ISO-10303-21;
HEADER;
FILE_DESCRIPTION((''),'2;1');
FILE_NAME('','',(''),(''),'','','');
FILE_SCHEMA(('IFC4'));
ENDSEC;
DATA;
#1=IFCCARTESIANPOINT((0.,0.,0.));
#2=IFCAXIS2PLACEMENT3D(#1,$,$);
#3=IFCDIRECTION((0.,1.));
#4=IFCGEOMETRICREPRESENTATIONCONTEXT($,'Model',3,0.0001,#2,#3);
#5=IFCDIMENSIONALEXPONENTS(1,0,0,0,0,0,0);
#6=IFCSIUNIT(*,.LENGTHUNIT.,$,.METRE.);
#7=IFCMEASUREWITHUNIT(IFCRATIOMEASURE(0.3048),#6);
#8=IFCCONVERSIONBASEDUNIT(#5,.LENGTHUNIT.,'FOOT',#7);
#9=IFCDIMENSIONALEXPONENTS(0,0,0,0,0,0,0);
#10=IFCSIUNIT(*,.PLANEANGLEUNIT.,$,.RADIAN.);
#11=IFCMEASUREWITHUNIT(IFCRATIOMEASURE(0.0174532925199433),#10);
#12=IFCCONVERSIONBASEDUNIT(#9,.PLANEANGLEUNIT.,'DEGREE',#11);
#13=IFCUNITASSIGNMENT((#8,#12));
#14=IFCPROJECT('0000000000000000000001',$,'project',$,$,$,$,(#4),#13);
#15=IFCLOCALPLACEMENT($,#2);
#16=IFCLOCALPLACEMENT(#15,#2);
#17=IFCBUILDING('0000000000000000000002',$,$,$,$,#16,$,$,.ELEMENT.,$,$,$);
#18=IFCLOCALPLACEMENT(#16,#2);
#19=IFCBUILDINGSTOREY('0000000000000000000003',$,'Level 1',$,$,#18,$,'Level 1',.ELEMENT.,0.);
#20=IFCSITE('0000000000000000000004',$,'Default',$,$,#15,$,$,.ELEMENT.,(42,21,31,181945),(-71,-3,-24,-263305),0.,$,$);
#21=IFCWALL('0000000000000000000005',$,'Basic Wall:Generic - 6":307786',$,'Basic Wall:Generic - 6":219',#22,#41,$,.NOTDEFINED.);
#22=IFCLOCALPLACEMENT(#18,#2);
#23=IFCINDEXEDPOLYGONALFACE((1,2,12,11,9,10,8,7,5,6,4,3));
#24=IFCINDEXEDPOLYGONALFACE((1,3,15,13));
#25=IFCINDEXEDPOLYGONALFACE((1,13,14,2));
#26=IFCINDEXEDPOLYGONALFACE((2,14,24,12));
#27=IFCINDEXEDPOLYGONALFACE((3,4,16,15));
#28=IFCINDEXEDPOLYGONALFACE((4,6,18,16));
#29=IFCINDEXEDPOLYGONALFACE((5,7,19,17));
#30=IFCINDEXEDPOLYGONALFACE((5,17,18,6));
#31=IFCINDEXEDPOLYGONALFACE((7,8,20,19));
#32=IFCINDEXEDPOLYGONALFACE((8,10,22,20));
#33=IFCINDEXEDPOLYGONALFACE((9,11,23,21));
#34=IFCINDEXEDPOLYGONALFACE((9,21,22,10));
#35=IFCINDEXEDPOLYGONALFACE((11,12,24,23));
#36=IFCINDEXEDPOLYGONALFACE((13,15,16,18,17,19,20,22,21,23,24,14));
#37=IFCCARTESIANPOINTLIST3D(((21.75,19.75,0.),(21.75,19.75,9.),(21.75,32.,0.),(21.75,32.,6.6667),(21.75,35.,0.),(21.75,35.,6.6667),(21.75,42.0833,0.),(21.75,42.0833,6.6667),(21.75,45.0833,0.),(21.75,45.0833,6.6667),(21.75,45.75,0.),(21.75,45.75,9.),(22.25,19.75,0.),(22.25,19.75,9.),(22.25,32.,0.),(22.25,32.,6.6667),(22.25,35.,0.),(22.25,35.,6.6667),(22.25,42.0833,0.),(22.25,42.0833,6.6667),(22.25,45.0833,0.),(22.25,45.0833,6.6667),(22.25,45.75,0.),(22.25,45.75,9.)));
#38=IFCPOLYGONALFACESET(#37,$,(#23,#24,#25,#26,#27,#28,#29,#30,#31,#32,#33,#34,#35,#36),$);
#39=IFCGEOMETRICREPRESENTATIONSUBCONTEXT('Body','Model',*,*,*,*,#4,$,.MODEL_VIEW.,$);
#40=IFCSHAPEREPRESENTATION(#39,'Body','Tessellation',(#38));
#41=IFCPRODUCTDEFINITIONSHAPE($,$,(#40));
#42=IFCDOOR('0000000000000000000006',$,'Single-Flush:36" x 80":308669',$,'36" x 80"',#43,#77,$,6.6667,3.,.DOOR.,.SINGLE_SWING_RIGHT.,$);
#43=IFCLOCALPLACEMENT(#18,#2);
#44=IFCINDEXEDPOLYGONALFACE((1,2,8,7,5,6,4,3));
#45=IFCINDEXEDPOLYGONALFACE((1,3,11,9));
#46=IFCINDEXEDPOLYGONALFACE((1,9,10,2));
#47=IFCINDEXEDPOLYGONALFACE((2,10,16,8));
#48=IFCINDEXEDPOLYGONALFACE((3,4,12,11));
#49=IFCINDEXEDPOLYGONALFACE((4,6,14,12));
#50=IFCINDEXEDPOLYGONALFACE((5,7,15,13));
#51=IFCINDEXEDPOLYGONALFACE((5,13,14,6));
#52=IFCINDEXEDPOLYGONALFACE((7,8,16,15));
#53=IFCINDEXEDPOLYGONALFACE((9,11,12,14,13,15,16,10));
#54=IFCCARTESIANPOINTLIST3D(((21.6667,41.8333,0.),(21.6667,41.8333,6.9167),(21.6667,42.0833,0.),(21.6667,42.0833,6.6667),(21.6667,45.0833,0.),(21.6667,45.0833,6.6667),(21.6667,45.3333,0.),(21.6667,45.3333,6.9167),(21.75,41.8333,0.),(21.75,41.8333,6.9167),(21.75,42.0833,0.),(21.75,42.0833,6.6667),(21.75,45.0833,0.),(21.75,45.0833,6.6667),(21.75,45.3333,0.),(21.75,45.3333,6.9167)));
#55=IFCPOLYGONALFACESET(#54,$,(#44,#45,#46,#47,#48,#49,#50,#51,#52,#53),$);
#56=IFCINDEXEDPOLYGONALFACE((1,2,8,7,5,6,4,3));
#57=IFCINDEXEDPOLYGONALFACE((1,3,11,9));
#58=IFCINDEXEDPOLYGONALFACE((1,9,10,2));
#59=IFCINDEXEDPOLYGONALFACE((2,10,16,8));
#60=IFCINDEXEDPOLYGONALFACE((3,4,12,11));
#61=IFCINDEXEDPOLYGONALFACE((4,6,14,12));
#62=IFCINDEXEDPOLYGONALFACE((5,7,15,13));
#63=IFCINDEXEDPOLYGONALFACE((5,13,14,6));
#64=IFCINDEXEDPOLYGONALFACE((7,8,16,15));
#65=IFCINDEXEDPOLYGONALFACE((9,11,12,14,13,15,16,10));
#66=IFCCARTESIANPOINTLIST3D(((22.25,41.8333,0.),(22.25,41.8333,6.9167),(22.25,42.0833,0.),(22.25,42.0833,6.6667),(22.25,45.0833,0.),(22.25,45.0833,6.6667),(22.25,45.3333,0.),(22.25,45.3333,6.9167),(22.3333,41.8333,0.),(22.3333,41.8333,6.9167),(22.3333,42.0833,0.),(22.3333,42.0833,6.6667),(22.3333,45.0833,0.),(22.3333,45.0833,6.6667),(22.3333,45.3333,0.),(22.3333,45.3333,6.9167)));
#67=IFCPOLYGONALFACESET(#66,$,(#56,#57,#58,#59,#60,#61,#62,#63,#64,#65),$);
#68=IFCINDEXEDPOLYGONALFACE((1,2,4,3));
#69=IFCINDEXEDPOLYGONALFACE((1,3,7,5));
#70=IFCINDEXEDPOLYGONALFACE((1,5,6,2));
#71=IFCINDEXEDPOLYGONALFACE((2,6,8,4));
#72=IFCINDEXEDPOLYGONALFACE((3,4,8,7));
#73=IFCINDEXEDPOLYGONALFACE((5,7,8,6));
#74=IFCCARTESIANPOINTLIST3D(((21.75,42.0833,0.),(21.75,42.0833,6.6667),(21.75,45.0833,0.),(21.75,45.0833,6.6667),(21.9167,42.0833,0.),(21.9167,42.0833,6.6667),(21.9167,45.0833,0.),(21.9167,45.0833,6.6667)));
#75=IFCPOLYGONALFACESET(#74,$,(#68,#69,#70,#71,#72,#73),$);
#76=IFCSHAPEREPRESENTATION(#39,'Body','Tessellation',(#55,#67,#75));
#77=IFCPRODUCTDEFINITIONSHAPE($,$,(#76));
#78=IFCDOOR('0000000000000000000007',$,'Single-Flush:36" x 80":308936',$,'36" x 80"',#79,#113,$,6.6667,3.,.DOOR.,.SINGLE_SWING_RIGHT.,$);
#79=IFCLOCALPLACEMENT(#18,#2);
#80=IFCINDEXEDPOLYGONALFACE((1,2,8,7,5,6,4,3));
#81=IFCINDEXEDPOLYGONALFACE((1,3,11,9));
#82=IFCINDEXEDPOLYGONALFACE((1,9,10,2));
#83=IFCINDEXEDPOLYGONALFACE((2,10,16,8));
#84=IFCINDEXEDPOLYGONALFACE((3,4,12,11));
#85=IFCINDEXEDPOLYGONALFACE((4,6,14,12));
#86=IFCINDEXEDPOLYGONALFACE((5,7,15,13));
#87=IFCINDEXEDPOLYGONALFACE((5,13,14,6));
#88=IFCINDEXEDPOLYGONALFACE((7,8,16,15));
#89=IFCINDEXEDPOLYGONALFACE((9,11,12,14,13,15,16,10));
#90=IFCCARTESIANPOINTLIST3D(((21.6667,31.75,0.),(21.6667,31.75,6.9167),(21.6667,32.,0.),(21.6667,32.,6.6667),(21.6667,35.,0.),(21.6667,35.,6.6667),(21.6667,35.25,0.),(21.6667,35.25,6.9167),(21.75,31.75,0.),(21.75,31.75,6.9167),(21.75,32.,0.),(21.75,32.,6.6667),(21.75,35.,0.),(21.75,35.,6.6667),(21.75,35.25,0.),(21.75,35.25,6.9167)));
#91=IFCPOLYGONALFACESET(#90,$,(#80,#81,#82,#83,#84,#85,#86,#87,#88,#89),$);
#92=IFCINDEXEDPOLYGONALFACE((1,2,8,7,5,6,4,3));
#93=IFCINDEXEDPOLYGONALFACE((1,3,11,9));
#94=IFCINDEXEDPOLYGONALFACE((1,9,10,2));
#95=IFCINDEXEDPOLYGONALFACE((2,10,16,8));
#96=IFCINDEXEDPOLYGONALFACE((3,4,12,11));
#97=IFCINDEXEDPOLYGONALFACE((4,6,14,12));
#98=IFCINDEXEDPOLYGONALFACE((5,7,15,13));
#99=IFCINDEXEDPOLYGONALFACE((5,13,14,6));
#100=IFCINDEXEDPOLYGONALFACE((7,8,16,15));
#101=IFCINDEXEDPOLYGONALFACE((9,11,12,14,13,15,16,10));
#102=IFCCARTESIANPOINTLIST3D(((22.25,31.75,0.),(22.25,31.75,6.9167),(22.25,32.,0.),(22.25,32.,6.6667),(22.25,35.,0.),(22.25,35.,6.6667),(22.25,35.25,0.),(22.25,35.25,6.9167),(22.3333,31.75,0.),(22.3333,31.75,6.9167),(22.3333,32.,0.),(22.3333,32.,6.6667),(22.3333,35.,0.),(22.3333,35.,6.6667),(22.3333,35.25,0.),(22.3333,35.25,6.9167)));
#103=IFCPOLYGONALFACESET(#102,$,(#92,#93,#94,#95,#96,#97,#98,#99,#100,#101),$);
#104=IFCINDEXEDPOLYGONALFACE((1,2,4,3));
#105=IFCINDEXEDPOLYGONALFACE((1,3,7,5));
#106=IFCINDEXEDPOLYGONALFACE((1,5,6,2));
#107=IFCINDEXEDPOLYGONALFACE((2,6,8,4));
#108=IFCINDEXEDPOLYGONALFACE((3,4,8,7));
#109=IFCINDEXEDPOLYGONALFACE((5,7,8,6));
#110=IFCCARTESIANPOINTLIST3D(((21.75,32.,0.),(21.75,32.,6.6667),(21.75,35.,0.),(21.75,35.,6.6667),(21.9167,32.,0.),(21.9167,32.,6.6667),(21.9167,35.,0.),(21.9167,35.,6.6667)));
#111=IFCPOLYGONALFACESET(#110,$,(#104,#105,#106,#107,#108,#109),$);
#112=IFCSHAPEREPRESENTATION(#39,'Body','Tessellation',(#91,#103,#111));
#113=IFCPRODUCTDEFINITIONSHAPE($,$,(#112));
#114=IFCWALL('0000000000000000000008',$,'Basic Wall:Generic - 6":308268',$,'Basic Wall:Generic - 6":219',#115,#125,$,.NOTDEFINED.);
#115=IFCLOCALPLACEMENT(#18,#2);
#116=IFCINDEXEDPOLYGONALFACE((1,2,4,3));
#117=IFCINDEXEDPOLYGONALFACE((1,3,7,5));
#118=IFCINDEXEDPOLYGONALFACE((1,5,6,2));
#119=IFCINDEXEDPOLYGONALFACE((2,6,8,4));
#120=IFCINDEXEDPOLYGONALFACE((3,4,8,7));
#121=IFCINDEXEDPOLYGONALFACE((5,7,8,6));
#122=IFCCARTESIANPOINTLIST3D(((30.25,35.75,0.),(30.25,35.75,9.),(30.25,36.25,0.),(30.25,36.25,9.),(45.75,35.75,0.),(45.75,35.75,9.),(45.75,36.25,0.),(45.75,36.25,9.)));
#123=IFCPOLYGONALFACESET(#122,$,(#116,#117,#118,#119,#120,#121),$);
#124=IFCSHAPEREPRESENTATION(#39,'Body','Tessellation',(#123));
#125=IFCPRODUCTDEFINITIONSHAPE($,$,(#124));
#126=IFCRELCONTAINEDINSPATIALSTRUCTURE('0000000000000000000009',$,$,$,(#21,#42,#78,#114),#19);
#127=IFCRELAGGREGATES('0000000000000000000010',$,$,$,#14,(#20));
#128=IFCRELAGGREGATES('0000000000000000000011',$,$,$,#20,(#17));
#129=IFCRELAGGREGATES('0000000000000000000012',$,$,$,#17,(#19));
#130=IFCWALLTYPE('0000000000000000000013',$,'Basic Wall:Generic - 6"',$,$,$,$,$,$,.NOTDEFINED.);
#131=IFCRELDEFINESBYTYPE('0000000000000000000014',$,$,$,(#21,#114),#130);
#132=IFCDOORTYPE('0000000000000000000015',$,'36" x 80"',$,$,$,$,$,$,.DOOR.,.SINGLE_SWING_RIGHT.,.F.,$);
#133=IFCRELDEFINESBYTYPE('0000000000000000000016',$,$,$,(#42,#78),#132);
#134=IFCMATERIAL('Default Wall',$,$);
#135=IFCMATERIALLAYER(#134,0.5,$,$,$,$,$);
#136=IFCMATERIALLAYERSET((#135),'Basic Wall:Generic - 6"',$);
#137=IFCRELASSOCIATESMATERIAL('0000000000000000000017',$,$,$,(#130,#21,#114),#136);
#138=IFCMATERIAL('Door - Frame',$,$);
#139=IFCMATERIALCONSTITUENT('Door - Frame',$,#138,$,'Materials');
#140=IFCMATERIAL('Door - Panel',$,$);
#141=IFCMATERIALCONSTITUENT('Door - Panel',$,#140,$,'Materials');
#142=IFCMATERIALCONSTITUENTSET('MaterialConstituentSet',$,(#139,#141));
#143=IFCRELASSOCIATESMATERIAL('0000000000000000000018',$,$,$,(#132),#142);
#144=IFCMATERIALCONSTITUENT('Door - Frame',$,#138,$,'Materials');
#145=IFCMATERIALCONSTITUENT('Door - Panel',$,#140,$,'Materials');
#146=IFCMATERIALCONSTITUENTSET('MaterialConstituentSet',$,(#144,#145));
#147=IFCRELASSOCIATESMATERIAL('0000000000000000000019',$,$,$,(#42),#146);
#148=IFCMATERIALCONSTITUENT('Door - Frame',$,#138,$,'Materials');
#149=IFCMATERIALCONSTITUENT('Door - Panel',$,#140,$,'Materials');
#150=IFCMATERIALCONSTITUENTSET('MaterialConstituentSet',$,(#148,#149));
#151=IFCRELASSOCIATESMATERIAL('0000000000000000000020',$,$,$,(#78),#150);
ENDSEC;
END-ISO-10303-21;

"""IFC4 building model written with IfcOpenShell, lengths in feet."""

from ifc_helpers import new_model, entity, si_unit, converted_unit, direction, frame, frame_2d, origin, origin_2d_with_axis, place, context, subcontext, project, spatial, polyline, rectangle, outline, extrude, clip, bounded_halfspace, source, transform, mapped, material, layer, layer_set, layer_usage, constituent, constituent_set, type_object, type_shapes, element, fill, save


model = new_model("IFC4")

# Units and contexts
model_context = context("Model", 3, precision=0.0001, world=origin(), true_north=direction((0.0, 1.0)))
body_context = subcontext(model_context, "Body", "Model", "MODEL_VIEW")
ifc_project = project(units=[converted_unit("LENGTHUNIT", "FOOT", entity("IfcRatioMeasure", 0.3048), si_unit("LENGTHUNIT", "METRE"), dimensions=[1, 0, 0, 0, 0, 0, 0]), converted_unit("PLANEANGLEUNIT", "DEGREE", entity("IfcRatioMeasure", 0.0174532925199433), si_unit("PLANEANGLEUNIT", "RADIAN"), dimensions=[0, 0, 0, 0, 0, 0, 0])], contexts=[model_context])

# Site, building, storey
site_placement = place(None, origin())
site = spatial("IfcSite", under=ifc_project, at=site_placement, Name="Default", CompositionType="ELEMENT", RefLatitude=(42, 21, 31, 181945), RefLongitude=(-71, -3, -24, -263305), RefElevation=0.0)
building_placement = place(site_placement, origin())
building = spatial("IfcBuilding", under=site, at=building_placement, CompositionType="ELEMENT")
storey_placement = place(building_placement, origin())
storey = spatial("IfcBuildingStorey", under=building, at=storey_placement, Name="Level 1", LongName="Level 1", CompositionType="ELEMENT", Elevation=0.0)

# Shared definitions
ifc_material_1 = material(Name="Default Wall")
ifc_layer = layer(ifc_material_1, 0.5)
ifc_layer_set = layer_set([ifc_layer], Name="Basic Wall:Generic - 6\"")
wall_type = type_object("IfcWallType", Name="Basic Wall:Generic - 6\"", PredefinedType="NOTDEFINED", material=ifc_layer_set)
ifc_material_2 = material(Name="Door - Frame")
ifc_material_3 = material(Name="Door - Panel")
ifc_constituent_1 = constituent(ifc_material_2, Name="Door - Frame", Category="Materials")
ifc_constituent_2 = constituent(ifc_material_3, Name="Door - Panel", Category="Materials")
ifc_constituent_set_1 = constituent_set(constituents=[ifc_constituent_1, ifc_constituent_2], Name="MaterialConstituentSet")
door_type_1 = type_object("IfcDoorType", Name="36\" x 80\"", OperationType="SINGLE_SWING_RIGHT", ParameterTakesPrecedence=False, PredefinedType="DOOR", material=ifc_constituent_set_1)
shared_shape_1 = source(origin(), body_context, "Body", "SweptSolid", [
    extrude(outline(polyline([(-1.75, -3.5208), (1.75, -3.5208), (1.75, 3.3958), (1.5, 3.3958), (1.5, -3.2708), (-1.5, -3.2708), (-1.5, 3.3958), (-1.75, 3.3958), (-1.75, -3.5208)])), frame((1.5, 0.5, 3.3958), z_axis=(0.0, 1.0, 0.0), x_axis=(1.0, 0.0, 0.0)), (0.0, 0.0, 1.0), 0.0833),
    extrude(outline(polyline([(-3.5208, -1.75), (3.3958, -1.75), (3.3958, -1.5), (-3.2708, -1.5), (-3.2708, 1.5), (3.3958, 1.5), (3.3958, 1.75), (-3.5208, 1.75), (-3.5208, -1.75)])), frame((1.5, -0.0833, 3.3958), z_axis=(0.0, 1.0, 0.0), x_axis=(0.0, 0.0, -1.0)), (0.0, 0.0, 1.0), 0.0833),
    extrude(rectangle(XDim=0.1667, YDim=3.0, at=origin_2d_with_axis()), frame((1.5, 0.4167, 0.0), z_axis=(0.0, 0.0, 1.0), x_axis=(0.0, 1.0, 0.0)), (0.0, 0.0, 1.0), 6.6667),
])
type_shapes(door_type_1, [shared_shape_1])

# Wall, openings, doors
ifc_layer_usage_1 = layer_usage(ifc_layer_set, "AXIS2", "NEGATIVE", 0.25)
wall_1_placement = place(storey_placement, frame((22.0, 45.75, 0.0), z_axis=(0.0, 0.0, 1.0), x_axis=(0.0, -1.0, 0.0)))
wall_1 = element("IfcWall", 1, at=wall_1_placement, inside=storey, type_object=wall_type, material=ifc_layer_usage_1, Name="Basic Wall:Generic - 6\":307786", ObjectType="Basic Wall:Generic - 6\":219", PredefinedType="NOTDEFINED", context=body_context, shape_type="Clipping", body=[
    clip(extrude(rectangle(XDim=26.0, YDim=0.5, at=frame_2d((13.0, 0.0), x_axis=(-1.0, 0.0))), origin(), (0.0, 0.0, 1.0), 9.0), bounded_halfspace(frame((0.0, -0.25, 9.0), z_axis=(0.0, 0.0, -1.0), x_axis=(-1.0, 0.0, 0.0)), True, frame((0.0, -0.25, 9.0)), polyline([(0.0, 0.0), (9.5, 0.0), (10.0, 0.0), (25.5, 0.0), (25.5, 0.5), (0.0, 0.5), (0.0, 0.0)]))),
])
opening_1_placement = place(wall_1_placement, frame((3.6667, 0.25, 0.0)))
opening_1 = element("IfcOpeningElement", 2, at=opening_1_placement, cuts=wall_1, ObjectType="Opening", PredefinedType="OPENING", context=body_context, shape_type="SweptSolid", body=[
    extrude(rectangle(XDim=3.0, YDim=6.6667, at=frame_2d((3.3333, 1.5), x_axis=(0.0, 1.0))), frame((0.0, 0.0, 0.0), z_axis=(0.0, -1.0, 0.0), x_axis=(0.0, 0.0, 1.0)), (0.0, 0.0, 1.0), 0.5),
])
opening_2_placement = place(wall_1_placement, frame((13.75, 0.25, 0.0)))
opening_2 = element("IfcOpeningElement", 3, at=opening_2_placement, cuts=wall_1, ObjectType="Opening", PredefinedType="OPENING", context=body_context, shape_type="SweptSolid", body=[
    extrude(rectangle(XDim=3.0, YDim=6.6667, at=frame_2d((3.3333, 1.5), x_axis=(0.0, 1.0))), frame((0.0, 0.0, 0.0), z_axis=(0.0, -1.0, 0.0), x_axis=(0.0, 0.0, 1.0)), (0.0, 0.0, 1.0), 0.5),
])
ifc_constituent_3 = constituent(ifc_material_2, Name="Door - Frame", Category="Materials")
ifc_constituent_4 = constituent(ifc_material_3, Name="Door - Panel", Category="Materials")
ifc_constituent_set_2 = constituent_set(constituents=[ifc_constituent_3, ifc_constituent_4], Name="MaterialConstituentSet")
door_1_placement = place(opening_1_placement, frame((0.0, 0.0, 0.0), z_axis=(0.0, 0.0, 1.0), x_axis=(-1.0, 0.0, 0.0)))
door_1 = element("IfcDoor", 4, at=door_1_placement, inside=storey, type_object=door_type_1, material=ifc_constituent_set_2, Name="Single-Flush:36\" x 80\":308669", ObjectType="36\" x 80\"", OperationType="SINGLE_SWING_RIGHT", OverallHeight=6.6667, OverallWidth=3.0, PredefinedType="DOOR", context=body_context, shape_type="MappedRepresentation", body=[
    mapped(shared_shape_1, transform((0.0, 0.0, 0.0), scale=1.0)),
])
fill(opening_1, door_1)
ifc_constituent_5 = constituent(ifc_material_2, Name="Door - Frame", Category="Materials")
ifc_constituent_6 = constituent(ifc_material_3, Name="Door - Panel", Category="Materials")
ifc_constituent_set_3 = constituent_set(constituents=[ifc_constituent_5, ifc_constituent_6], Name="MaterialConstituentSet")
door_2_placement = place(opening_2_placement, frame((0.0, 0.0, 0.0), z_axis=(0.0, 0.0, 1.0), x_axis=(-1.0, 0.0, 0.0)))
door_2 = element("IfcDoor", 5, at=door_2_placement, inside=storey, type_object=door_type_1, material=ifc_constituent_set_3, Name="Single-Flush:36\" x 80\":308936", ObjectType="36\" x 80\"", OperationType="SINGLE_SWING_RIGHT", OverallHeight=6.6667, OverallWidth=3.0, PredefinedType="DOOR", context=body_context, shape_type="MappedRepresentation", body=[
    mapped(shared_shape_1, transform((0.0, 0.0, 0.0), scale=1.0)),
])
fill(opening_2, door_2)

# Wall
ifc_layer_usage_2 = layer_usage(ifc_layer_set, "AXIS2", "NEGATIVE", 0.25)
wall_2_placement = place(storey_placement, frame((30.25, 36.0, 0.0)))
element("IfcWall", 6, at=wall_2_placement, inside=storey, type_object=wall_type, material=ifc_layer_usage_2, Name="Basic Wall:Generic - 6\":308268", ObjectType="Basic Wall:Generic - 6\":219", PredefinedType="NOTDEFINED", context=body_context, shape_type="Clipping", body=[
    clip(extrude(rectangle(XDim=15.5, YDim=0.5, at=frame_2d((7.75, 0.0), x_axis=(-1.0, 0.0))), origin(), (0.0, 0.0, 1.0), 9.0), bounded_halfspace(frame((0.0, -0.25, 9.0), z_axis=(0.0, 0.0, -1.0), x_axis=(0.0, -1.0, 0.0)), True, frame((0.0, -0.25, 9.0)), polyline([(0.0, 0.0), (15.5, 0.0), (15.5, 0.5), (0.0, 0.5), (0.0, 0.0)]))),
])

save(model, "model.ifc")
